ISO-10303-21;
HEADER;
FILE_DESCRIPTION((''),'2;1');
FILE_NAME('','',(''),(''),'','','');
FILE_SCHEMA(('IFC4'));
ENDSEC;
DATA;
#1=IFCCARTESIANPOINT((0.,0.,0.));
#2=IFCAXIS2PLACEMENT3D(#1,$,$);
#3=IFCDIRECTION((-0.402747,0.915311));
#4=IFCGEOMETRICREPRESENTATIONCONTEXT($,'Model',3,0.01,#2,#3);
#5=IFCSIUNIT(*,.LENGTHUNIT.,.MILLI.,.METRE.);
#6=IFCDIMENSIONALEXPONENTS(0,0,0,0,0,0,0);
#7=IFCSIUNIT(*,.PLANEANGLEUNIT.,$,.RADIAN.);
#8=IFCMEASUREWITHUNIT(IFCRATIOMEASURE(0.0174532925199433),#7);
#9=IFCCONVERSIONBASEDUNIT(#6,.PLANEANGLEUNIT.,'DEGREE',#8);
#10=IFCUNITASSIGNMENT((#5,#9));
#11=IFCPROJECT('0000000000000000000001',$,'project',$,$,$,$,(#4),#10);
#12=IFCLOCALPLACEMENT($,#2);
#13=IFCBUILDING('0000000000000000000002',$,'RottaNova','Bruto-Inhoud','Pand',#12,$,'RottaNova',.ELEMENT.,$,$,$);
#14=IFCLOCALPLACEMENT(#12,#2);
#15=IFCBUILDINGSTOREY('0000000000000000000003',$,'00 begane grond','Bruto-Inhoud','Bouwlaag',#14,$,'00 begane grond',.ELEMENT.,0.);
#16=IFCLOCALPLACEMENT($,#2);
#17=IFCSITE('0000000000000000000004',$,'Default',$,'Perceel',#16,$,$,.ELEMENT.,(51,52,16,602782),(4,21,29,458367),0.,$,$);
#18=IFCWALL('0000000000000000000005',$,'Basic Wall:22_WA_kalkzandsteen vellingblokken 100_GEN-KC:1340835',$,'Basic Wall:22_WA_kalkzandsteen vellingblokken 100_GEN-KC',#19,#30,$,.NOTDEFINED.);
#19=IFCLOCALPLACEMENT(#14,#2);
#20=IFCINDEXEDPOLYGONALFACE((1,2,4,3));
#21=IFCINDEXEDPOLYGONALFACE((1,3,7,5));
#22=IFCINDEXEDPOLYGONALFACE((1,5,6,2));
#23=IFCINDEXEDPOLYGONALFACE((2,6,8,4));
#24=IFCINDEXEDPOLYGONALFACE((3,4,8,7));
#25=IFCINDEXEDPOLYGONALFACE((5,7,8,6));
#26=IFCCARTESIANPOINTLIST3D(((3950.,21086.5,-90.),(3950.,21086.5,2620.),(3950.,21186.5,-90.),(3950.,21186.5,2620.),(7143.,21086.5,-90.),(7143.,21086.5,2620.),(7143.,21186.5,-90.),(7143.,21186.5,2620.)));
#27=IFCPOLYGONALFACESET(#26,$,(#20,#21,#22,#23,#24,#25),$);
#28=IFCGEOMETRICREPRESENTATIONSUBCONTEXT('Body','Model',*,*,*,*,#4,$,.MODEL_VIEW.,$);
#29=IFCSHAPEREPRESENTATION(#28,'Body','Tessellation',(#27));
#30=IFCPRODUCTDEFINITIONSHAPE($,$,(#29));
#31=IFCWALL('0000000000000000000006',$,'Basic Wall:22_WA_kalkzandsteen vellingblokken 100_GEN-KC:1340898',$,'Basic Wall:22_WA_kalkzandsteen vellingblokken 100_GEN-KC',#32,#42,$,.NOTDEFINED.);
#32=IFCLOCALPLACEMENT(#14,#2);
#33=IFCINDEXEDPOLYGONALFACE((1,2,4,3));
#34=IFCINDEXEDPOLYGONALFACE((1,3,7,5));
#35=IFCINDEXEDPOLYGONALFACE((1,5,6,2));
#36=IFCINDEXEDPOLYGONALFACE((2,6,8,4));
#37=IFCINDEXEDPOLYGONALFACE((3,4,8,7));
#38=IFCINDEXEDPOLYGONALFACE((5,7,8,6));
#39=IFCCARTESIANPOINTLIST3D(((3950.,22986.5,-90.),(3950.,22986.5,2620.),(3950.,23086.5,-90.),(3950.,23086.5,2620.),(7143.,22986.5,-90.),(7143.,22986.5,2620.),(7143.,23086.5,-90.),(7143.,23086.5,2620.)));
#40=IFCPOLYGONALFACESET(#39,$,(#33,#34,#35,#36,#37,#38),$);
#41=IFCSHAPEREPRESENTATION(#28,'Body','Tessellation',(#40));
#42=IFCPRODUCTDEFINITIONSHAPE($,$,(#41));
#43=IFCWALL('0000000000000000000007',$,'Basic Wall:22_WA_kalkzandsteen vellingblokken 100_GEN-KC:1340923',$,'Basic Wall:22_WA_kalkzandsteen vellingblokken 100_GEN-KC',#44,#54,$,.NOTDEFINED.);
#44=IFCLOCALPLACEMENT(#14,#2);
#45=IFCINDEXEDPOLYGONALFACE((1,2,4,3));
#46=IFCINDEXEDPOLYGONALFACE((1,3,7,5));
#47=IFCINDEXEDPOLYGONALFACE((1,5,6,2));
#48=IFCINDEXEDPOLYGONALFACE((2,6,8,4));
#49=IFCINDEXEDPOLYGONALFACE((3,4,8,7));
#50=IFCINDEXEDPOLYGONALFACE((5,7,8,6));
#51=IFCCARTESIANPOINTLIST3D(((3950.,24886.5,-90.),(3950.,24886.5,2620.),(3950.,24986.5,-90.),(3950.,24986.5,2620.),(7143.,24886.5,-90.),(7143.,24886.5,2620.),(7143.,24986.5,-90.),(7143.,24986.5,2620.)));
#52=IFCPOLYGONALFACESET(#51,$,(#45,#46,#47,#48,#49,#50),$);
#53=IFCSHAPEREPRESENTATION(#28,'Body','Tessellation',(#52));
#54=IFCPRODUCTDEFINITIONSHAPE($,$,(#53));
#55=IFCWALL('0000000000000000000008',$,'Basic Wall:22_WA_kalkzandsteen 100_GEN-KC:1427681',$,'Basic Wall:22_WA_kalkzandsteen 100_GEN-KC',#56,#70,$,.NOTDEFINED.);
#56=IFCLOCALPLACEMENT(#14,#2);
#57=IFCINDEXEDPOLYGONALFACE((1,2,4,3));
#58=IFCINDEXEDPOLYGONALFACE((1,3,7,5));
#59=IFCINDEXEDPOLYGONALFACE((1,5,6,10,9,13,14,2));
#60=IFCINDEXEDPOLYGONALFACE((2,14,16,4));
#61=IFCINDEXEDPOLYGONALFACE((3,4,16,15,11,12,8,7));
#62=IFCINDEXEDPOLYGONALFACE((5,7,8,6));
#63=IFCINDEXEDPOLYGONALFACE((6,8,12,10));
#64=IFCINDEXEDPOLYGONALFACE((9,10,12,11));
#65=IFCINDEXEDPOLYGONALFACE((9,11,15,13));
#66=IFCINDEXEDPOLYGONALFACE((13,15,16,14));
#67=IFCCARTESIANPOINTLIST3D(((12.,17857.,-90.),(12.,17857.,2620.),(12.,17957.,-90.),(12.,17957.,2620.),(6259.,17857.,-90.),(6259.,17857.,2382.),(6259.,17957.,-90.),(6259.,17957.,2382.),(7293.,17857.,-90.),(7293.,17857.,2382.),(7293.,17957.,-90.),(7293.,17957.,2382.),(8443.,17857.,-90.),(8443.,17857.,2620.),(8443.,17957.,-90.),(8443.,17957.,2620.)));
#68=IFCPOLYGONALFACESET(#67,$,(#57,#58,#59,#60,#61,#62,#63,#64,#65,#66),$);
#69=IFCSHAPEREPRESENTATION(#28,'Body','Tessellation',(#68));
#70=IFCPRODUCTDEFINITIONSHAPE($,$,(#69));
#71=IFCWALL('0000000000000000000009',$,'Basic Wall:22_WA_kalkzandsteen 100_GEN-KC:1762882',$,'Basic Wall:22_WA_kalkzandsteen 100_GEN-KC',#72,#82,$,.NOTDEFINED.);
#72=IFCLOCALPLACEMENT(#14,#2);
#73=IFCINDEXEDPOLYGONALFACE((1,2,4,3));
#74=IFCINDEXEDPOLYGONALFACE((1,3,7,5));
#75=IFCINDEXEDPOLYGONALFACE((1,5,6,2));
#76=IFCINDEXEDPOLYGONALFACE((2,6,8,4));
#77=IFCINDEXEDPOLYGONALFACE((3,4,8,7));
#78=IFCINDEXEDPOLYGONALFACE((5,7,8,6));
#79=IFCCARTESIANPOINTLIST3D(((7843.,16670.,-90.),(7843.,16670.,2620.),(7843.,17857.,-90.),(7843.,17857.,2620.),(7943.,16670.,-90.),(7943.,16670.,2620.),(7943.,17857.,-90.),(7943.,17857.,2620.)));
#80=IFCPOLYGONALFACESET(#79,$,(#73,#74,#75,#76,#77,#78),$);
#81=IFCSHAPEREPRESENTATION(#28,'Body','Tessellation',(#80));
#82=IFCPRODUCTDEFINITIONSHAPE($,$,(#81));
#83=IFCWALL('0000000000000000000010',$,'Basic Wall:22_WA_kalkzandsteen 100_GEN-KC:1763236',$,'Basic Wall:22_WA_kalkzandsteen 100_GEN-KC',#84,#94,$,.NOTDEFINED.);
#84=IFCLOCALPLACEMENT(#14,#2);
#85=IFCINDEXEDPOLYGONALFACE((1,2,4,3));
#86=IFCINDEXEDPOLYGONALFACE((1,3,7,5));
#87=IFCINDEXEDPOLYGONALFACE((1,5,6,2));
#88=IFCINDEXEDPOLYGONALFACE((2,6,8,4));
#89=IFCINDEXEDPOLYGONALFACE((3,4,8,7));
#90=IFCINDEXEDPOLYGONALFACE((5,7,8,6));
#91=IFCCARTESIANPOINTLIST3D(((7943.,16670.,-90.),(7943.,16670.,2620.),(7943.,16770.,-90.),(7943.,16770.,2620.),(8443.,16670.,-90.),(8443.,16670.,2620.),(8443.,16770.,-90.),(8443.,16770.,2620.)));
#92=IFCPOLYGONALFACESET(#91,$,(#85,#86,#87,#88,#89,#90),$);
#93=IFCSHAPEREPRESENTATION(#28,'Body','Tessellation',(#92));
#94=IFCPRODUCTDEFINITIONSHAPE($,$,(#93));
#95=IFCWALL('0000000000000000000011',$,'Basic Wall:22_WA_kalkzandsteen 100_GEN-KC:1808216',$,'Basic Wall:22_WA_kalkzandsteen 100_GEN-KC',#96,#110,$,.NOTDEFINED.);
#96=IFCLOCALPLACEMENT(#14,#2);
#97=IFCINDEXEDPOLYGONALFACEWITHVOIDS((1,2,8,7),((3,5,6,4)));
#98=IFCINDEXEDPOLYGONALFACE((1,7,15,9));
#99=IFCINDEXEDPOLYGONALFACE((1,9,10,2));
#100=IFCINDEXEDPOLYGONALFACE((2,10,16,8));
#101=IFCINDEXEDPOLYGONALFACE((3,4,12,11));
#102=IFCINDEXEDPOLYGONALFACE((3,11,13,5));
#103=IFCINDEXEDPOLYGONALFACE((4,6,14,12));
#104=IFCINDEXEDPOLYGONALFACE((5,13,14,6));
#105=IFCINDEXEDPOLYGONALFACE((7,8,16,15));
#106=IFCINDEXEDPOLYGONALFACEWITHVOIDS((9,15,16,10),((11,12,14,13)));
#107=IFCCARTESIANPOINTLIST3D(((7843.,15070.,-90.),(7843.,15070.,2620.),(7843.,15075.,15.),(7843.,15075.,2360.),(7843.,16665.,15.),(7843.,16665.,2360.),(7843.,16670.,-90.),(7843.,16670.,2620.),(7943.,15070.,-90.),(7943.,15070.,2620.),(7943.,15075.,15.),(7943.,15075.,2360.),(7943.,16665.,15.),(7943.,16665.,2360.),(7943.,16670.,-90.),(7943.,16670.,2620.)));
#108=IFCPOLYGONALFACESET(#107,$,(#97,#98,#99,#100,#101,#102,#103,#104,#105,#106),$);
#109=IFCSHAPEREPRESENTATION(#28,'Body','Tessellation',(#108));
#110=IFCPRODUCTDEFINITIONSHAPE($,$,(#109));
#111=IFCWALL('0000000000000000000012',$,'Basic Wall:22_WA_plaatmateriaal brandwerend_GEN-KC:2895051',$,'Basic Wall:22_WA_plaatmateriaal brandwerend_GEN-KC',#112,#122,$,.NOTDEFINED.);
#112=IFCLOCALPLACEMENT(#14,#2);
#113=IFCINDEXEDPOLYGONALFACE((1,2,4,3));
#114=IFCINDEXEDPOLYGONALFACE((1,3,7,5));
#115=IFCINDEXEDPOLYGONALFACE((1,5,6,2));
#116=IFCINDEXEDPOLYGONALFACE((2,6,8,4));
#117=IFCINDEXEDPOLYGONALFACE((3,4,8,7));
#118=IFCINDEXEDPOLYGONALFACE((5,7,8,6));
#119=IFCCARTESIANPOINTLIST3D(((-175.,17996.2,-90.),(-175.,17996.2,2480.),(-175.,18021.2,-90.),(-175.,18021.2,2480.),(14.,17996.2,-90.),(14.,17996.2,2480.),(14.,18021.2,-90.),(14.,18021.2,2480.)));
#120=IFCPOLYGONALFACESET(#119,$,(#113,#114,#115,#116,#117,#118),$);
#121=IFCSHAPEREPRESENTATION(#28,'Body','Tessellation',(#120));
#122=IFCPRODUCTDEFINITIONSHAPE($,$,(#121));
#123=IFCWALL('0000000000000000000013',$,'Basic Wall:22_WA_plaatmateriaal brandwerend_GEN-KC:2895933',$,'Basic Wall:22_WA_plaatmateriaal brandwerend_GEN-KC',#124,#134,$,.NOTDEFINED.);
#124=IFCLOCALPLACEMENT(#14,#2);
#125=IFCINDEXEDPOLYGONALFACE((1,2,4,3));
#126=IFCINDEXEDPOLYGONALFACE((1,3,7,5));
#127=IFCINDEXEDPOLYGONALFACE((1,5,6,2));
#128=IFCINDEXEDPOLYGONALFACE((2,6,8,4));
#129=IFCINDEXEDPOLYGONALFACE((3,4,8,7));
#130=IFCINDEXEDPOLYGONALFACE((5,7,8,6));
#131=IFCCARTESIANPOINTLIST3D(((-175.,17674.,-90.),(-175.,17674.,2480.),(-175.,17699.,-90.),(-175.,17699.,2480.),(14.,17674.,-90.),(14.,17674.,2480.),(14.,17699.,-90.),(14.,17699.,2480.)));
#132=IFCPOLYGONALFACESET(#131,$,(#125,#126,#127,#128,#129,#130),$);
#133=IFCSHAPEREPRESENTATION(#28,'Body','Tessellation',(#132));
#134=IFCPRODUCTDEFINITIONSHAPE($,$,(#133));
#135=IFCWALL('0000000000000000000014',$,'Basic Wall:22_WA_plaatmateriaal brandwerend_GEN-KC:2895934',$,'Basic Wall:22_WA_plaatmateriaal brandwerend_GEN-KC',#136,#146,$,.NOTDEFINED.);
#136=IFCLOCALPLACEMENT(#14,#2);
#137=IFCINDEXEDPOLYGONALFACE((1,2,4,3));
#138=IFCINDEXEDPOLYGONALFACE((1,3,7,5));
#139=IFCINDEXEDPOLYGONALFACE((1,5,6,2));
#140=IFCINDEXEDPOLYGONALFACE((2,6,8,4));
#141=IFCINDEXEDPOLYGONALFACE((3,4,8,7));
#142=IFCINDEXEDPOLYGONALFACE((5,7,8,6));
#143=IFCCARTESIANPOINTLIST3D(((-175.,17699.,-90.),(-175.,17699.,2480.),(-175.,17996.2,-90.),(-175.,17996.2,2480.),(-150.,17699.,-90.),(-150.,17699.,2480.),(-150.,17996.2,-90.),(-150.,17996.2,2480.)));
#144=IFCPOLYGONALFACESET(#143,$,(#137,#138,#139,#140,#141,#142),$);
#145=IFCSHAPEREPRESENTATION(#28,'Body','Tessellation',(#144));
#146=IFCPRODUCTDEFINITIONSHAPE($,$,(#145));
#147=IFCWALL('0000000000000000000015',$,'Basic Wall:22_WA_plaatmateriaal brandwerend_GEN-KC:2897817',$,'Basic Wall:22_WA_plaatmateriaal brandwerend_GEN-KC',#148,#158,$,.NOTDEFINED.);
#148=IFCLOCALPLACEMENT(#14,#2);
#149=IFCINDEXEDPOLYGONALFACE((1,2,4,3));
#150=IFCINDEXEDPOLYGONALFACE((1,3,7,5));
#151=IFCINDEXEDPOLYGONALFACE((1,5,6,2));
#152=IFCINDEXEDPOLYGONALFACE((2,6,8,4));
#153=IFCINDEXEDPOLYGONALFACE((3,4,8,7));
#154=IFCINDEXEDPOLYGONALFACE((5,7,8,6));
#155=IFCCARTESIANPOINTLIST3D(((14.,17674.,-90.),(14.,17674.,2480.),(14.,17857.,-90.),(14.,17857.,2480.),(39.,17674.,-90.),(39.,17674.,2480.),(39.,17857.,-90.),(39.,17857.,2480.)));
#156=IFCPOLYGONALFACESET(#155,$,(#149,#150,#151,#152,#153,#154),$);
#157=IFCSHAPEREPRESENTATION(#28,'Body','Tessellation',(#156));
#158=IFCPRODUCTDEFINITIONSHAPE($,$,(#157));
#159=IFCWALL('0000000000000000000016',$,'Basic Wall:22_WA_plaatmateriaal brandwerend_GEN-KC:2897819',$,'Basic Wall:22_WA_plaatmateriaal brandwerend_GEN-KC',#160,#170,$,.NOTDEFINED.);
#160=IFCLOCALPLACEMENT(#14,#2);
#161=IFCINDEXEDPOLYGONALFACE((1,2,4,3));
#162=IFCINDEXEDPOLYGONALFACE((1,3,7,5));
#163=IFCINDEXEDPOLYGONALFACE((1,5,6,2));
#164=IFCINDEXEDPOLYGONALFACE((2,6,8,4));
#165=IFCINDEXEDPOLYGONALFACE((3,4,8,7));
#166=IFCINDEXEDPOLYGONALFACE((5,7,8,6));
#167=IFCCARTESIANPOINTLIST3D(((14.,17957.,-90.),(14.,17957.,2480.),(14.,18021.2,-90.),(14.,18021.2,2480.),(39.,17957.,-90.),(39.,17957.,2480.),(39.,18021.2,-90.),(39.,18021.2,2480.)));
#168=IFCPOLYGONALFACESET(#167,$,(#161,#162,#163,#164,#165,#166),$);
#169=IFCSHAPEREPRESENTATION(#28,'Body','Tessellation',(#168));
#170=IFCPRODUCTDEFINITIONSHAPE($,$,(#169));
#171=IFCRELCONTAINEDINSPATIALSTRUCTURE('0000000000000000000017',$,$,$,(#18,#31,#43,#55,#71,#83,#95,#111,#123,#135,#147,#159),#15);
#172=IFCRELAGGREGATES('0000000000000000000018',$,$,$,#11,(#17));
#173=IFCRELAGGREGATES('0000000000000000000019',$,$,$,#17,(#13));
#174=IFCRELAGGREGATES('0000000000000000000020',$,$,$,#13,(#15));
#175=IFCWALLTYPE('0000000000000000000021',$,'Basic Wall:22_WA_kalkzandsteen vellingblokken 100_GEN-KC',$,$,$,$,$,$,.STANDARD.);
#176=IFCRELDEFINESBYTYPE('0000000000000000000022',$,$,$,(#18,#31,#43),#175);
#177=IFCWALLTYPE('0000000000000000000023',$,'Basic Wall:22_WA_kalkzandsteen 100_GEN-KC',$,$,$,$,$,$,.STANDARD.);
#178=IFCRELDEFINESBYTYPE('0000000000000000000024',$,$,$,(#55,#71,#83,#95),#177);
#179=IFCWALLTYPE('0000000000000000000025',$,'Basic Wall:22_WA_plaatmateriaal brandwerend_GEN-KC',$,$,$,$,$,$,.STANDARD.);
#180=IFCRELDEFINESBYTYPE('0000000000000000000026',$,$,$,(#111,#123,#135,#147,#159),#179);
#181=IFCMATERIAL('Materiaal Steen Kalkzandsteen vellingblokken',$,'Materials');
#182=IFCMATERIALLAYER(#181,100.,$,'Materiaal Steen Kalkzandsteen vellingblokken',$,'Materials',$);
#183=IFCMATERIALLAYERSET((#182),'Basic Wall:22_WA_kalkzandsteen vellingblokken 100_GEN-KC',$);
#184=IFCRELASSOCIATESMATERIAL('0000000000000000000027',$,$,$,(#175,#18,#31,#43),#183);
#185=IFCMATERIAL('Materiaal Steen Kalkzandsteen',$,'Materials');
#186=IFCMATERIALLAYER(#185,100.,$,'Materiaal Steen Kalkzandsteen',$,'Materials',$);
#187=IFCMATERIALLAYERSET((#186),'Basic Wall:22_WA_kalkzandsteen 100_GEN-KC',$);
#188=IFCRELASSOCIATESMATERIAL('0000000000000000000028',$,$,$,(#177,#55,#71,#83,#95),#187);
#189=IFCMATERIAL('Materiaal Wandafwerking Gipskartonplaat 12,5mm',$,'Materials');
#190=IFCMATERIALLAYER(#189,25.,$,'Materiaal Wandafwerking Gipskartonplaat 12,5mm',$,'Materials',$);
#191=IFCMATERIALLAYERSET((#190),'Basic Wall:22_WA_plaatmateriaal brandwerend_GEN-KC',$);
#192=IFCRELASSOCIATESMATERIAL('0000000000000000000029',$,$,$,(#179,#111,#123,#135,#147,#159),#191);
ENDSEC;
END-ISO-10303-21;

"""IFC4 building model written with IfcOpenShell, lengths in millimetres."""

from ifc_helpers import new_model, entity, si_unit, converted_unit, direction, frame, frame_2d, origin, place, context, subcontext, project, spatial, rectangle, extrude, material, layer, layer_set, type_object, element, save


model = new_model("IFC4")

# Units and contexts
model_context = context("Model", 3, precision=0.01, world=origin(), true_north=direction((-0.402747, 0.915311)))
body_context = subcontext(model_context, "Body", "Model", "MODEL_VIEW")
ifc_project = project(units=[si_unit("LENGTHUNIT", "METRE", prefix="MILLI"), converted_unit("PLANEANGLEUNIT", "DEGREE", entity("IfcRatioMeasure", 0.0174532925199433), si_unit("PLANEANGLEUNIT", "RADIAN"), dimensions=[0, 0, 0, 0, 0, 0, 0])], contexts=[model_context])

# Site, building, storey
site_placement = place(None, origin())
site = spatial("IfcSite", under=ifc_project, at=site_placement, Name="Default", ObjectType="Perceel", CompositionType="ELEMENT", RefLatitude=(51, 52, 16, 602782), RefLongitude=(4, 21, 29, 458367), RefElevation=0.0)
building_placement = place(None, origin())
building = spatial("IfcBuilding", under=site, at=building_placement, Name="RottaNova", Description="Bruto-Inhoud", ObjectType="Pand", LongName="RottaNova", CompositionType="ELEMENT")
storey_placement = place(building_placement, origin())
storey = spatial("IfcBuildingStorey", under=building, at=storey_placement, Name="00 begane grond", Description="Bruto-Inhoud", ObjectType="Bouwlaag", LongName="00 begane grond", CompositionType="ELEMENT", Elevation=0.0)

# Shared definitions
ifc_material_1 = material(Name="Materiaal Steen Kalkzandsteen vellingblokken", Category="Materials")
ifc_layer_1 = layer(ifc_material_1, 100.0, Name="Materiaal Steen Kalkzandsteen vellingblokken", Category="Materials")
ifc_layer_set_1 = layer_set([ifc_layer_1], Name="Basic Wall:22_WA_kalkzandsteen vellingblokken 100_GEN-KC")
wall_type_1 = type_object("IfcWallType", Name="Basic Wall:22_WA_kalkzandsteen vellingblokken 100_GEN-KC", PredefinedType="STANDARD", material=ifc_layer_set_1)

# Walls
for number, where, name in (
    (1, (3950.0, 21136.5, -90.0), "Basic Wall:22_WA_kalkzandsteen vellingblokken 100_GEN-KC:1340835"),
    (2, (3950.0, 23036.5, -90.0), "Basic Wall:22_WA_kalkzandsteen vellingblokken 100_GEN-KC:1340898"),
    (3, (3950.0, 24936.5, -90.0), "Basic Wall:22_WA_kalkzandsteen vellingblokken 100_GEN-KC:1340923"),
):
    element("IfcWall", number, at=place(storey_placement, frame(where)), inside=storey, type_object=wall_type_1, material=ifc_layer_set_1, Name=name, ObjectType="Basic Wall:22_WA_kalkzandsteen vellingblokken 100_GEN-KC", PredefinedType="NOTDEFINED", context=body_context, shape_type="SweptSolid", body=[
        extrude(rectangle(XDim=3193.0, YDim=100.0, at=frame_2d((1596.5, 0.0), x_axis=(-1.0, 0.0))), origin(), (0.0, 0.0, 1.0), 2710.0),
    ])

# Wall, opening
ifc_material_2 = material(Name="Materiaal Steen Kalkzandsteen", Category="Materials")
ifc_layer_2 = layer(ifc_material_2, 100.0, Name="Materiaal Steen Kalkzandsteen", Category="Materials")
ifc_layer_set_2 = layer_set([ifc_layer_2], Name="Basic Wall:22_WA_kalkzandsteen 100_GEN-KC")
wall_type_2 = type_object("IfcWallType", Name="Basic Wall:22_WA_kalkzandsteen 100_GEN-KC", PredefinedType="STANDARD", material=ifc_layer_set_2)
wall_1_placement = place(storey_placement, frame((12.0, 17907.0, -90.0)))
wall_1 = element("IfcWall", 4, at=wall_1_placement, inside=storey, type_object=wall_type_2, material=ifc_layer_set_2, Name="Basic Wall:22_WA_kalkzandsteen 100_GEN-KC:1427681", ObjectType="Basic Wall:22_WA_kalkzandsteen 100_GEN-KC", PredefinedType="NOTDEFINED", context=body_context, shape_type="SweptSolid", body=[
    extrude(rectangle(XDim=8431.0, YDim=100.0, at=frame_2d((4215.5, 0.0), x_axis=(-1.0, 0.0))), origin(), (0.0, 0.0, 1.0), 2710.0),
])
opening_1_placement = place(wall_1_placement, frame((7281.0, 50.0, 0.0)))
element("IfcOpeningElement", 5, at=opening_1_placement, cuts=wall_1, PredefinedType="OPENING", context=body_context, shape_type="SweptSolid", body=[
    extrude(rectangle(XDim=2472.0, YDim=1034.0, at=frame_2d((1236.0, 517.0), x_axis=(1.0, 0.0))), frame((0.0, 0.0, 0.0), z_axis=(0.0, -1.0, 0.0), x_axis=(0.0, 0.0, 1.0)), (0.0, 0.0, 1.0), 100.0),
])

# Walls
wall_2_placement = place(storey_placement, frame((7893.0, 17857.0, -90.0), z_axis=(0.0, 0.0, 1.0), x_axis=(0.0, -1.0, 0.0)))
element("IfcWall", 6, at=wall_2_placement, inside=storey, type_object=wall_type_2, material=ifc_layer_set_2, Name="Basic Wall:22_WA_kalkzandsteen 100_GEN-KC:1762882", ObjectType="Basic Wall:22_WA_kalkzandsteen 100_GEN-KC", PredefinedType="NOTDEFINED", context=body_context, shape_type="SweptSolid", body=[
    extrude(rectangle(XDim=1187.0, YDim=100.0, at=frame_2d((593.5, 0.0), x_axis=(-1.0, 0.0))), origin(), (0.0, 0.0, 1.0), 2710.0),
])
wall_3_placement = place(storey_placement, frame((8443.0, 16720.0, -90.0), z_axis=(0.0, 0.0, 1.0), x_axis=(-1.0, 0.0, 0.0)))
element("IfcWall", 7, at=wall_3_placement, inside=storey, type_object=wall_type_2, material=ifc_layer_set_2, Name="Basic Wall:22_WA_kalkzandsteen 100_GEN-KC:1763236", ObjectType="Basic Wall:22_WA_kalkzandsteen 100_GEN-KC", PredefinedType="NOTDEFINED", context=body_context, shape_type="SweptSolid", body=[
    extrude(rectangle(XDim=500.0, YDim=100.0, at=frame_2d((250.0, 0.0), x_axis=(-1.0, 0.0))), origin(), (0.0, 0.0, 1.0), 2710.0),
])

# Wall, opening
wall_4_placement = place(storey_placement, frame((7893.0, 16670.0, -90.0), z_axis=(0.0, 0.0, 1.0), x_axis=(0.0, -1.0, 0.0)))
wall_4 = element("IfcWall", 8, at=wall_4_placement, inside=storey, type_object=wall_type_2, material=ifc_layer_set_2, Name="Basic Wall:22_WA_kalkzandsteen 100_GEN-KC:1808216", ObjectType="Basic Wall:22_WA_kalkzandsteen 100_GEN-KC", PredefinedType="NOTDEFINED", context=body_context, shape_type="SweptSolid", body=[
    extrude(rectangle(XDim=1600.0, YDim=100.0, at=frame_2d((800.0, 0.0), x_axis=(-1.0, 0.0))), origin(), (0.0, 0.0, 1.0), 2710.0),
])
opening_2_placement = place(wall_4_placement, frame((1595.0, -1474.0, 105.0), z_axis=(0.0, 0.0, 1.0), x_axis=(0.0, 1.0, 0.0)))
element("IfcOpeningElement", 9, at=opening_2_placement, cuts=wall_4, PredefinedType="OPENING", context=body_context, shape_type="SweptSolid", body=[
    extrude(rectangle(XDim=2345.0, YDim=1590.0, at=frame_2d((0.0, 0.0), x_axis=(1.0, 0.0))), frame((0.0, 795.0, 1172.5), z_axis=(1.0, 0.0, 0.0), x_axis=(0.0, 0.0, -1.0)), (0.0, 0.0, 1.0), 3048.0),
])

# Walls
ifc_material_3 = material(Name="Materiaal Wandafwerking Gipskartonplaat 12,5mm", Category="Materials")
ifc_layer_3 = layer(ifc_material_3, 25.0, Name="Materiaal Wandafwerking Gipskartonplaat 12,5mm", Category="Materials")
ifc_layer_set_3 = layer_set([ifc_layer_3], Name="Basic Wall:22_WA_plaatmateriaal brandwerend_GEN-KC")
wall_type_3 = type_object("IfcWallType", Name="Basic Wall:22_WA_plaatmateriaal brandwerend_GEN-KC", PredefinedType="STANDARD", material=ifc_layer_set_3)
wall_5_placement = place(storey_placement, frame((-175.0, 18008.7, -90.0)))
element("IfcWall", 10, at=wall_5_placement, inside=storey, type_object=wall_type_3, material=ifc_layer_set_3, Name="Basic Wall:22_WA_plaatmateriaal brandwerend_GEN-KC:2895051", ObjectType="Basic Wall:22_WA_plaatmateriaal brandwerend_GEN-KC", PredefinedType="NOTDEFINED", context=body_context, shape_type="SweptSolid", body=[
    extrude(rectangle(XDim=189.0, YDim=25.0, at=frame_2d((94.5, 0.0), x_axis=(-1.0, 0.0))), origin(), (0.0, 0.0, 1.0), 2570.0),
])
wall_6_placement = place(storey_placement, frame((-175.0, 17686.5, -90.0)))
element("IfcWall", 11, at=wall_6_placement, inside=storey, type_object=wall_type_3, material=ifc_layer_set_3, Name="Basic Wall:22_WA_plaatmateriaal brandwerend_GEN-KC:2895933", ObjectType="Basic Wall:22_WA_plaatmateriaal brandwerend_GEN-KC", PredefinedType="NOTDEFINED", context=body_context, shape_type="SweptSolid", body=[
    extrude(rectangle(XDim=189.0, YDim=25.0, at=frame_2d((94.5, 0.0), x_axis=(-1.0, 0.0))), origin(), (0.0, 0.0, 1.0), 2570.0),
])
wall_7_placement = place(storey_placement, frame((-162.5, 17699.0, -90.0), z_axis=(0.0, 0.0, 1.0), x_axis=(0.0, 1.0, 0.0)))
element("IfcWall", 12, at=wall_7_placement, inside=storey, type_object=wall_type_3, material=ifc_layer_set_3, Name="Basic Wall:22_WA_plaatmateriaal brandwerend_GEN-KC:2895934", ObjectType="Basic Wall:22_WA_plaatmateriaal brandwerend_GEN-KC", PredefinedType="NOTDEFINED", context=body_context, shape_type="SweptSolid", body=[
    extrude(rectangle(XDim=297.2, YDim=25.0, at=frame_2d((148.6, 0.0), x_axis=(-1.0, 0.0))), origin(), (0.0, 0.0, 1.0), 2570.0),
])
wall_8_placement = place(storey_placement, frame((26.5, 17674.0, -90.0), z_axis=(0.0, 0.0, 1.0), x_axis=(0.0, 1.0, 0.0)))
element("IfcWall", 13, at=wall_8_placement, inside=storey, type_object=wall_type_3, material=ifc_layer_set_3, Name="Basic Wall:22_WA_plaatmateriaal brandwerend_GEN-KC:2897817", ObjectType="Basic Wall:22_WA_plaatmateriaal brandwerend_GEN-KC", PredefinedType="NOTDEFINED", context=body_context, shape_type="SweptSolid", body=[
    extrude(rectangle(XDim=183.0, YDim=25.0, at=frame_2d((91.5, 0.0), x_axis=(-1.0, 0.0))), origin(), (0.0, 0.0, 1.0), 2570.0),
])
wall_9_placement = place(storey_placement, frame((26.5, 17957.0, -90.0), z_axis=(0.0, 0.0, 1.0), x_axis=(0.0, 1.0, 0.0)))
element("IfcWall", 14, at=wall_9_placement, inside=storey, type_object=wall_type_3, material=ifc_layer_set_3, Name="Basic Wall:22_WA_plaatmateriaal brandwerend_GEN-KC:2897819", ObjectType="Basic Wall:22_WA_plaatmateriaal brandwerend_GEN-KC", PredefinedType="NOTDEFINED", context=body_context, shape_type="SweptSolid", body=[
    extrude(rectangle(XDim=64.2, YDim=25.0, at=frame_2d((32.1, 0.0), x_axis=(-1.0, 0.0))), origin(), (0.0, 0.0, 1.0), 2570.0),
])

save(model, "model.ifc")
